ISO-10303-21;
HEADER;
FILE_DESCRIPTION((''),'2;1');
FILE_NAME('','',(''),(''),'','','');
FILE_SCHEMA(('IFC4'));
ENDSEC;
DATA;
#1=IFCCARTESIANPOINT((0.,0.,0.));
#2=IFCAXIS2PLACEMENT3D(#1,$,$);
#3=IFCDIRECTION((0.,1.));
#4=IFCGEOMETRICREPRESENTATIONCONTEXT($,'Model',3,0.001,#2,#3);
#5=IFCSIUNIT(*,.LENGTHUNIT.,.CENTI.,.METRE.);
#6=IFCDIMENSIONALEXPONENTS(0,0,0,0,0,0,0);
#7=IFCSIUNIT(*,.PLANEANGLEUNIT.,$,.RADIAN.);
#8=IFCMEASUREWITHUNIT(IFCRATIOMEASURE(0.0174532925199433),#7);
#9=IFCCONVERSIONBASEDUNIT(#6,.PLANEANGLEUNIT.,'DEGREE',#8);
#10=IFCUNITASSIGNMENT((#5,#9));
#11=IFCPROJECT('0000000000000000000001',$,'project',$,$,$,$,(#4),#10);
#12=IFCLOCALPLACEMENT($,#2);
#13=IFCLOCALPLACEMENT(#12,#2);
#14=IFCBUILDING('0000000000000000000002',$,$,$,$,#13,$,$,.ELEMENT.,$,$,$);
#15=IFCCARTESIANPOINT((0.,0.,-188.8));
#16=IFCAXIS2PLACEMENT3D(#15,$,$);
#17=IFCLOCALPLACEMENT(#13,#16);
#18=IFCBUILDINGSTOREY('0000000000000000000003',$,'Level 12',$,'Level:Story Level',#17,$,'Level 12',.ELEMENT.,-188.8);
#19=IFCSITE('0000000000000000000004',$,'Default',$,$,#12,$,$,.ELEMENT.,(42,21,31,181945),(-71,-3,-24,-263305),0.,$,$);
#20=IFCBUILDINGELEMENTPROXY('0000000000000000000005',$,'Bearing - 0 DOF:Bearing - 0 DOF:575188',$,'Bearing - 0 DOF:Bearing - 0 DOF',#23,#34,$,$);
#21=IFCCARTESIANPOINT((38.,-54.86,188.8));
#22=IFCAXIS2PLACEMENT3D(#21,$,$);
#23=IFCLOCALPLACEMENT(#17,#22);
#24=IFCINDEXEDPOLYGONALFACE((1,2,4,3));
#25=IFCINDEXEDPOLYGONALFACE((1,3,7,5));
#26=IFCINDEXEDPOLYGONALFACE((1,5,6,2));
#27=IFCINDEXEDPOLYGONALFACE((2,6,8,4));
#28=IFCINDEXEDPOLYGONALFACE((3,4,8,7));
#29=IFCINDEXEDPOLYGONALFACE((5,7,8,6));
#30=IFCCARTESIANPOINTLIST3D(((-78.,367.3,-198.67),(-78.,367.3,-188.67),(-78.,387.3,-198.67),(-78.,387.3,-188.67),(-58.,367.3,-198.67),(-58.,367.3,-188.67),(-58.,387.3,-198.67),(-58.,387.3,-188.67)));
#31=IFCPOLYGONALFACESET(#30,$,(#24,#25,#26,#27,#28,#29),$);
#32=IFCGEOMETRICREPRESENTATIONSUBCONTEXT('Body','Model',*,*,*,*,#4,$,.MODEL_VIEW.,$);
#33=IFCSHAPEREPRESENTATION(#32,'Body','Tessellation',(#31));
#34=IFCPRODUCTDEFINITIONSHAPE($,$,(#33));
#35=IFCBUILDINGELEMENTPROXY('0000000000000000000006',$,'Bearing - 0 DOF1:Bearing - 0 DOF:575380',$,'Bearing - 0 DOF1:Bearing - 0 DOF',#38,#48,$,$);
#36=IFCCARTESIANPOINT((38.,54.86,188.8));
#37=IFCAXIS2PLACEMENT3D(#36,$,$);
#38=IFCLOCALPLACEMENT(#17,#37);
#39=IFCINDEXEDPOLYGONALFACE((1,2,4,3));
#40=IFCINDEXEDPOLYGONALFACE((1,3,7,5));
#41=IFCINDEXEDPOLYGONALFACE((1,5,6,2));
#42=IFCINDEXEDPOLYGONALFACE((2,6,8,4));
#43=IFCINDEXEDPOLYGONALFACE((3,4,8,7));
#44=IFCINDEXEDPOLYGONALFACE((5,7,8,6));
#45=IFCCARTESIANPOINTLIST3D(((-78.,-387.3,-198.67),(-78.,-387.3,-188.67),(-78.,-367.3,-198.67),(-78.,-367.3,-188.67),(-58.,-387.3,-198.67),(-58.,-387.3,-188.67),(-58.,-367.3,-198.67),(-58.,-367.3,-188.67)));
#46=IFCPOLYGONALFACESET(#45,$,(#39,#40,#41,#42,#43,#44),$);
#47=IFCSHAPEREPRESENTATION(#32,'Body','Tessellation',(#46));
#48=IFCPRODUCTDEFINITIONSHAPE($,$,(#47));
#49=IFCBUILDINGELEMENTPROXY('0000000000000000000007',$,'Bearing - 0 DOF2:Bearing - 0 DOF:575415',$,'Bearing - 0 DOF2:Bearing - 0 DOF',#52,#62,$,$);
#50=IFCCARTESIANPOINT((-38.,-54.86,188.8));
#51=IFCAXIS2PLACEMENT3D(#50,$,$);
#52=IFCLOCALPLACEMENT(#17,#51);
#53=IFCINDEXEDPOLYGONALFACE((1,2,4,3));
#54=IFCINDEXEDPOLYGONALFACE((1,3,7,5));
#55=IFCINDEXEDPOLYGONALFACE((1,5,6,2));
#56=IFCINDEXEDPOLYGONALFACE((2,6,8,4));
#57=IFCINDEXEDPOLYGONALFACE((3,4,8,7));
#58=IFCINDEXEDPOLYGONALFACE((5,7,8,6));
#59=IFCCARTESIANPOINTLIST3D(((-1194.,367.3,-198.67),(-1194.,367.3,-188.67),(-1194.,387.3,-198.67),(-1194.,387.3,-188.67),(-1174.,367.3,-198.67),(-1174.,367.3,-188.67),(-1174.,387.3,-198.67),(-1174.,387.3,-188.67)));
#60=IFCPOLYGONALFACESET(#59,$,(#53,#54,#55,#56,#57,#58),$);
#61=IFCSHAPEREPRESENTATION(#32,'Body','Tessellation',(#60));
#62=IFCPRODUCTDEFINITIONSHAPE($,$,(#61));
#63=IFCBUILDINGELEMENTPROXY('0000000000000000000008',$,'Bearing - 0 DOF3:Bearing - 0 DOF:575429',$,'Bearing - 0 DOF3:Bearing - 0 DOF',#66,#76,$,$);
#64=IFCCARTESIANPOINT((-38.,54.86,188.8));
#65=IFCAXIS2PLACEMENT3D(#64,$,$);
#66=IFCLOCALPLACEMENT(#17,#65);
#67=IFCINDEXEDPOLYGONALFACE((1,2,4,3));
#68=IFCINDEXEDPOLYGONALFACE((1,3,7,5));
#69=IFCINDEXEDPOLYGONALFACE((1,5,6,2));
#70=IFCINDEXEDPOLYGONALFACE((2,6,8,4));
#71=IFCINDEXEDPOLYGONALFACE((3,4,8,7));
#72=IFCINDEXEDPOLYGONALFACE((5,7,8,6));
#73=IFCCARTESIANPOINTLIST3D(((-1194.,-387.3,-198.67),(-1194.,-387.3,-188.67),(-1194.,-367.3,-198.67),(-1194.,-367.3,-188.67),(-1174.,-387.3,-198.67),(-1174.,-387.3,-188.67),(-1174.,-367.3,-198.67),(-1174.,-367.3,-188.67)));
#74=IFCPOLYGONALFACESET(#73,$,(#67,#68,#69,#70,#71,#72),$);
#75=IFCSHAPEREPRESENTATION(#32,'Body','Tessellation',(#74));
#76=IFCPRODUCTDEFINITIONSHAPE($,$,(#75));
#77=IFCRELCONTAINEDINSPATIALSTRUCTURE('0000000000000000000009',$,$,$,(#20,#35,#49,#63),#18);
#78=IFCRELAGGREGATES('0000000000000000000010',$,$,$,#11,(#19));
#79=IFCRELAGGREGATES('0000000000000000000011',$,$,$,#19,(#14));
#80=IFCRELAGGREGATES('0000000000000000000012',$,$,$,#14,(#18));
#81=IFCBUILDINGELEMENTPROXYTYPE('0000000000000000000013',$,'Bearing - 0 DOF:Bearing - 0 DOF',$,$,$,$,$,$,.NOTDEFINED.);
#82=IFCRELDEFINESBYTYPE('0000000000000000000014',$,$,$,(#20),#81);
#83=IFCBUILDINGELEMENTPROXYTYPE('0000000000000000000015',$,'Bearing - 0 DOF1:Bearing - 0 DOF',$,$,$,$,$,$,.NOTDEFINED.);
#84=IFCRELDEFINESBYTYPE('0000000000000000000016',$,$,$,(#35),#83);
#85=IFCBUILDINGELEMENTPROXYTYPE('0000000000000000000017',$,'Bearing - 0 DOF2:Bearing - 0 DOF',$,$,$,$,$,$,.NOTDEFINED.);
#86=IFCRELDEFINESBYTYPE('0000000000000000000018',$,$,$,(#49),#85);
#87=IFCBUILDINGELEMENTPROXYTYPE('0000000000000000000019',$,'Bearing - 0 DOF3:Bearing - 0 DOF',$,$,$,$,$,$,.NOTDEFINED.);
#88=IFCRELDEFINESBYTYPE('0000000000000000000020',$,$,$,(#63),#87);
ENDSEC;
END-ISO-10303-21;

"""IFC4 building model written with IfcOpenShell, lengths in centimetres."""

from ifc_helpers import new_model, entity, si_unit, converted_unit, direction, frame, frame_2d, origin, origin_2d_with_axis, place, context, subcontext, project, spatial, rectangle, extrude, source, transform, mapped, type_object, type_shapes, element, save


model = new_model("IFC4")

# Units and contexts
model_context = context("Model", 3, precision=0.001, world=origin(), true_north=direction((0.0, 1.0)))
body_context = subcontext(model_context, "Body", "Model", "MODEL_VIEW")
ifc_project = project(units=[si_unit("LENGTHUNIT", "METRE", prefix="CENTI"), converted_unit("PLANEANGLEUNIT", "DEGREE", entity("IfcRatioMeasure", 0.0174532925199433), si_unit("PLANEANGLEUNIT", "RADIAN"), dimensions=[0, 0, 0, 0, 0, 0, 0])], contexts=[model_context])

# Site, building, storey
site_placement = place(None, origin())
site = spatial("IfcSite", under=ifc_project, at=site_placement, Name="Default", CompositionType="ELEMENT", RefLatitude=(42, 21, 31, 181945), RefLongitude=(-71, -3, -24, -263305), RefElevation=0.0)
building_placement = place(site_placement, origin())
building = spatial("IfcBuilding", under=site, at=building_placement, CompositionType="ELEMENT")
storey_placement = place(building_placement, frame((0.0, 0.0, -188.8)))
storey = spatial("IfcBuildingStorey", under=building, at=storey_placement, Name="Level 12", ObjectType="Level:Story Level", LongName="Level 12", CompositionType="ELEMENT", Elevation=-188.8)

# Building element proxies
building_element_proxy_type_1 = type_object("IfcBuildingElementProxyType", Name="Bearing - 0 DOF:Bearing - 0 DOF", PredefinedType="NOTDEFINED")
shared_shape_1 = source(origin(), body_context, "Body", "SweptSolid", [
    extrude(rectangle(XDim=20.0, YDim=20.0, at=origin_2d_with_axis()), frame((-68.0, 377.3, -198.67), z_axis=(0.0, 0.0, 1.0), x_axis=(-1.0, 0.0, 0.0)), (0.0, 0.0, 1.0), 10.0),
])
type_shapes(building_element_proxy_type_1, [shared_shape_1])
proxy_1_placement = place(storey_placement, frame((38.0, -54.86, 188.8)))
element("IfcBuildingElementProxy", 1, at=proxy_1_placement, inside=storey, type_object=building_element_proxy_type_1, Name="Bearing - 0 DOF:Bearing - 0 DOF:575188", ObjectType="Bearing - 0 DOF:Bearing - 0 DOF", context=body_context, shape_type="MappedRepresentation", body=[
    mapped(shared_shape_1, transform((0.0, 0.0, 0.0), scale=1.0)),
])
building_element_proxy_type_2 = type_object("IfcBuildingElementProxyType", Name="Bearing - 0 DOF1:Bearing - 0 DOF", PredefinedType="NOTDEFINED")
shared_shape_2 = source(origin(), body_context, "Body", "SweptSolid", [
    extrude(rectangle(XDim=20.0, YDim=20.0, at=origin_2d_with_axis()), frame((-68.0, -377.3, -198.67), z_axis=(0.0, 0.0, 1.0), x_axis=(0.0, 1.0, 0.0)), (0.0, 0.0, 1.0), 10.0),
])
type_shapes(building_element_proxy_type_2, [shared_shape_2])
proxy_2_placement = place(storey_placement, frame((38.0, 54.86, 188.8)))
element("IfcBuildingElementProxy", 2, at=proxy_2_placement, inside=storey, type_object=building_element_proxy_type_2, Name="Bearing - 0 DOF1:Bearing - 0 DOF:575380", ObjectType="Bearing - 0 DOF1:Bearing - 0 DOF", context=body_context, shape_type="MappedRepresentation", body=[
    mapped(shared_shape_2, transform((0.0, 0.0, 0.0), scale=1.0)),
])
building_element_proxy_type_3 = type_object("IfcBuildingElementProxyType", Name="Bearing - 0 DOF2:Bearing - 0 DOF", PredefinedType="NOTDEFINED")
shared_shape_3 = source(origin(), body_context, "Body", "SweptSolid", [
    extrude(rectangle(XDim=20.0, YDim=20.0, at=frame_2d((0.0, 0.0), x_axis=(1.0, 0.0))), frame((-1184.0, 377.3, -198.67), z_axis=(0.0, 0.0, 1.0), x_axis=(0.0, -1.0, 0.0)), (0.0, 0.0, 1.0), 10.0),
])
type_shapes(building_element_proxy_type_3, [shared_shape_3])
proxy_3_placement = place(storey_placement, frame((-38.0, -54.86, 188.8)))
element("IfcBuildingElementProxy", 3, at=proxy_3_placement, inside=storey, type_object=building_element_proxy_type_3, Name="Bearing - 0 DOF2:Bearing - 0 DOF:575415", ObjectType="Bearing - 0 DOF2:Bearing - 0 DOF", context=body_context, shape_type="MappedRepresentation", body=[
    mapped(shared_shape_3, transform((0.0, 0.0, 0.0), scale=1.0)),
])
building_element_proxy_type_4 = type_object("IfcBuildingElementProxyType", Name="Bearing - 0 DOF3:Bearing - 0 DOF", PredefinedType="NOTDEFINED")
shared_shape_4 = source(origin(), body_context, "Body", "SweptSolid", [
    extrude(rectangle(XDim=20.0, YDim=20.0, at=frame_2d((0.0, 0.0), x_axis=(1.0, 0.0))), frame((-1184.0, -377.3, -198.67)), (0.0, 0.0, 1.0), 10.0),
])
type_shapes(building_element_proxy_type_4, [shared_shape_4])
proxy_4_placement = place(storey_placement, frame((-38.0, 54.86, 188.8)))
element("IfcBuildingElementProxy", 4, at=proxy_4_placement, inside=storey, type_object=building_element_proxy_type_4, Name="Bearing - 0 DOF3:Bearing - 0 DOF:575429", ObjectType="Bearing - 0 DOF3:Bearing - 0 DOF", context=body_context, shape_type="MappedRepresentation", body=[
    mapped(shared_shape_4, transform((0.0, 0.0, 0.0), scale=1.0)),
])

save(model, "model.ifc")
